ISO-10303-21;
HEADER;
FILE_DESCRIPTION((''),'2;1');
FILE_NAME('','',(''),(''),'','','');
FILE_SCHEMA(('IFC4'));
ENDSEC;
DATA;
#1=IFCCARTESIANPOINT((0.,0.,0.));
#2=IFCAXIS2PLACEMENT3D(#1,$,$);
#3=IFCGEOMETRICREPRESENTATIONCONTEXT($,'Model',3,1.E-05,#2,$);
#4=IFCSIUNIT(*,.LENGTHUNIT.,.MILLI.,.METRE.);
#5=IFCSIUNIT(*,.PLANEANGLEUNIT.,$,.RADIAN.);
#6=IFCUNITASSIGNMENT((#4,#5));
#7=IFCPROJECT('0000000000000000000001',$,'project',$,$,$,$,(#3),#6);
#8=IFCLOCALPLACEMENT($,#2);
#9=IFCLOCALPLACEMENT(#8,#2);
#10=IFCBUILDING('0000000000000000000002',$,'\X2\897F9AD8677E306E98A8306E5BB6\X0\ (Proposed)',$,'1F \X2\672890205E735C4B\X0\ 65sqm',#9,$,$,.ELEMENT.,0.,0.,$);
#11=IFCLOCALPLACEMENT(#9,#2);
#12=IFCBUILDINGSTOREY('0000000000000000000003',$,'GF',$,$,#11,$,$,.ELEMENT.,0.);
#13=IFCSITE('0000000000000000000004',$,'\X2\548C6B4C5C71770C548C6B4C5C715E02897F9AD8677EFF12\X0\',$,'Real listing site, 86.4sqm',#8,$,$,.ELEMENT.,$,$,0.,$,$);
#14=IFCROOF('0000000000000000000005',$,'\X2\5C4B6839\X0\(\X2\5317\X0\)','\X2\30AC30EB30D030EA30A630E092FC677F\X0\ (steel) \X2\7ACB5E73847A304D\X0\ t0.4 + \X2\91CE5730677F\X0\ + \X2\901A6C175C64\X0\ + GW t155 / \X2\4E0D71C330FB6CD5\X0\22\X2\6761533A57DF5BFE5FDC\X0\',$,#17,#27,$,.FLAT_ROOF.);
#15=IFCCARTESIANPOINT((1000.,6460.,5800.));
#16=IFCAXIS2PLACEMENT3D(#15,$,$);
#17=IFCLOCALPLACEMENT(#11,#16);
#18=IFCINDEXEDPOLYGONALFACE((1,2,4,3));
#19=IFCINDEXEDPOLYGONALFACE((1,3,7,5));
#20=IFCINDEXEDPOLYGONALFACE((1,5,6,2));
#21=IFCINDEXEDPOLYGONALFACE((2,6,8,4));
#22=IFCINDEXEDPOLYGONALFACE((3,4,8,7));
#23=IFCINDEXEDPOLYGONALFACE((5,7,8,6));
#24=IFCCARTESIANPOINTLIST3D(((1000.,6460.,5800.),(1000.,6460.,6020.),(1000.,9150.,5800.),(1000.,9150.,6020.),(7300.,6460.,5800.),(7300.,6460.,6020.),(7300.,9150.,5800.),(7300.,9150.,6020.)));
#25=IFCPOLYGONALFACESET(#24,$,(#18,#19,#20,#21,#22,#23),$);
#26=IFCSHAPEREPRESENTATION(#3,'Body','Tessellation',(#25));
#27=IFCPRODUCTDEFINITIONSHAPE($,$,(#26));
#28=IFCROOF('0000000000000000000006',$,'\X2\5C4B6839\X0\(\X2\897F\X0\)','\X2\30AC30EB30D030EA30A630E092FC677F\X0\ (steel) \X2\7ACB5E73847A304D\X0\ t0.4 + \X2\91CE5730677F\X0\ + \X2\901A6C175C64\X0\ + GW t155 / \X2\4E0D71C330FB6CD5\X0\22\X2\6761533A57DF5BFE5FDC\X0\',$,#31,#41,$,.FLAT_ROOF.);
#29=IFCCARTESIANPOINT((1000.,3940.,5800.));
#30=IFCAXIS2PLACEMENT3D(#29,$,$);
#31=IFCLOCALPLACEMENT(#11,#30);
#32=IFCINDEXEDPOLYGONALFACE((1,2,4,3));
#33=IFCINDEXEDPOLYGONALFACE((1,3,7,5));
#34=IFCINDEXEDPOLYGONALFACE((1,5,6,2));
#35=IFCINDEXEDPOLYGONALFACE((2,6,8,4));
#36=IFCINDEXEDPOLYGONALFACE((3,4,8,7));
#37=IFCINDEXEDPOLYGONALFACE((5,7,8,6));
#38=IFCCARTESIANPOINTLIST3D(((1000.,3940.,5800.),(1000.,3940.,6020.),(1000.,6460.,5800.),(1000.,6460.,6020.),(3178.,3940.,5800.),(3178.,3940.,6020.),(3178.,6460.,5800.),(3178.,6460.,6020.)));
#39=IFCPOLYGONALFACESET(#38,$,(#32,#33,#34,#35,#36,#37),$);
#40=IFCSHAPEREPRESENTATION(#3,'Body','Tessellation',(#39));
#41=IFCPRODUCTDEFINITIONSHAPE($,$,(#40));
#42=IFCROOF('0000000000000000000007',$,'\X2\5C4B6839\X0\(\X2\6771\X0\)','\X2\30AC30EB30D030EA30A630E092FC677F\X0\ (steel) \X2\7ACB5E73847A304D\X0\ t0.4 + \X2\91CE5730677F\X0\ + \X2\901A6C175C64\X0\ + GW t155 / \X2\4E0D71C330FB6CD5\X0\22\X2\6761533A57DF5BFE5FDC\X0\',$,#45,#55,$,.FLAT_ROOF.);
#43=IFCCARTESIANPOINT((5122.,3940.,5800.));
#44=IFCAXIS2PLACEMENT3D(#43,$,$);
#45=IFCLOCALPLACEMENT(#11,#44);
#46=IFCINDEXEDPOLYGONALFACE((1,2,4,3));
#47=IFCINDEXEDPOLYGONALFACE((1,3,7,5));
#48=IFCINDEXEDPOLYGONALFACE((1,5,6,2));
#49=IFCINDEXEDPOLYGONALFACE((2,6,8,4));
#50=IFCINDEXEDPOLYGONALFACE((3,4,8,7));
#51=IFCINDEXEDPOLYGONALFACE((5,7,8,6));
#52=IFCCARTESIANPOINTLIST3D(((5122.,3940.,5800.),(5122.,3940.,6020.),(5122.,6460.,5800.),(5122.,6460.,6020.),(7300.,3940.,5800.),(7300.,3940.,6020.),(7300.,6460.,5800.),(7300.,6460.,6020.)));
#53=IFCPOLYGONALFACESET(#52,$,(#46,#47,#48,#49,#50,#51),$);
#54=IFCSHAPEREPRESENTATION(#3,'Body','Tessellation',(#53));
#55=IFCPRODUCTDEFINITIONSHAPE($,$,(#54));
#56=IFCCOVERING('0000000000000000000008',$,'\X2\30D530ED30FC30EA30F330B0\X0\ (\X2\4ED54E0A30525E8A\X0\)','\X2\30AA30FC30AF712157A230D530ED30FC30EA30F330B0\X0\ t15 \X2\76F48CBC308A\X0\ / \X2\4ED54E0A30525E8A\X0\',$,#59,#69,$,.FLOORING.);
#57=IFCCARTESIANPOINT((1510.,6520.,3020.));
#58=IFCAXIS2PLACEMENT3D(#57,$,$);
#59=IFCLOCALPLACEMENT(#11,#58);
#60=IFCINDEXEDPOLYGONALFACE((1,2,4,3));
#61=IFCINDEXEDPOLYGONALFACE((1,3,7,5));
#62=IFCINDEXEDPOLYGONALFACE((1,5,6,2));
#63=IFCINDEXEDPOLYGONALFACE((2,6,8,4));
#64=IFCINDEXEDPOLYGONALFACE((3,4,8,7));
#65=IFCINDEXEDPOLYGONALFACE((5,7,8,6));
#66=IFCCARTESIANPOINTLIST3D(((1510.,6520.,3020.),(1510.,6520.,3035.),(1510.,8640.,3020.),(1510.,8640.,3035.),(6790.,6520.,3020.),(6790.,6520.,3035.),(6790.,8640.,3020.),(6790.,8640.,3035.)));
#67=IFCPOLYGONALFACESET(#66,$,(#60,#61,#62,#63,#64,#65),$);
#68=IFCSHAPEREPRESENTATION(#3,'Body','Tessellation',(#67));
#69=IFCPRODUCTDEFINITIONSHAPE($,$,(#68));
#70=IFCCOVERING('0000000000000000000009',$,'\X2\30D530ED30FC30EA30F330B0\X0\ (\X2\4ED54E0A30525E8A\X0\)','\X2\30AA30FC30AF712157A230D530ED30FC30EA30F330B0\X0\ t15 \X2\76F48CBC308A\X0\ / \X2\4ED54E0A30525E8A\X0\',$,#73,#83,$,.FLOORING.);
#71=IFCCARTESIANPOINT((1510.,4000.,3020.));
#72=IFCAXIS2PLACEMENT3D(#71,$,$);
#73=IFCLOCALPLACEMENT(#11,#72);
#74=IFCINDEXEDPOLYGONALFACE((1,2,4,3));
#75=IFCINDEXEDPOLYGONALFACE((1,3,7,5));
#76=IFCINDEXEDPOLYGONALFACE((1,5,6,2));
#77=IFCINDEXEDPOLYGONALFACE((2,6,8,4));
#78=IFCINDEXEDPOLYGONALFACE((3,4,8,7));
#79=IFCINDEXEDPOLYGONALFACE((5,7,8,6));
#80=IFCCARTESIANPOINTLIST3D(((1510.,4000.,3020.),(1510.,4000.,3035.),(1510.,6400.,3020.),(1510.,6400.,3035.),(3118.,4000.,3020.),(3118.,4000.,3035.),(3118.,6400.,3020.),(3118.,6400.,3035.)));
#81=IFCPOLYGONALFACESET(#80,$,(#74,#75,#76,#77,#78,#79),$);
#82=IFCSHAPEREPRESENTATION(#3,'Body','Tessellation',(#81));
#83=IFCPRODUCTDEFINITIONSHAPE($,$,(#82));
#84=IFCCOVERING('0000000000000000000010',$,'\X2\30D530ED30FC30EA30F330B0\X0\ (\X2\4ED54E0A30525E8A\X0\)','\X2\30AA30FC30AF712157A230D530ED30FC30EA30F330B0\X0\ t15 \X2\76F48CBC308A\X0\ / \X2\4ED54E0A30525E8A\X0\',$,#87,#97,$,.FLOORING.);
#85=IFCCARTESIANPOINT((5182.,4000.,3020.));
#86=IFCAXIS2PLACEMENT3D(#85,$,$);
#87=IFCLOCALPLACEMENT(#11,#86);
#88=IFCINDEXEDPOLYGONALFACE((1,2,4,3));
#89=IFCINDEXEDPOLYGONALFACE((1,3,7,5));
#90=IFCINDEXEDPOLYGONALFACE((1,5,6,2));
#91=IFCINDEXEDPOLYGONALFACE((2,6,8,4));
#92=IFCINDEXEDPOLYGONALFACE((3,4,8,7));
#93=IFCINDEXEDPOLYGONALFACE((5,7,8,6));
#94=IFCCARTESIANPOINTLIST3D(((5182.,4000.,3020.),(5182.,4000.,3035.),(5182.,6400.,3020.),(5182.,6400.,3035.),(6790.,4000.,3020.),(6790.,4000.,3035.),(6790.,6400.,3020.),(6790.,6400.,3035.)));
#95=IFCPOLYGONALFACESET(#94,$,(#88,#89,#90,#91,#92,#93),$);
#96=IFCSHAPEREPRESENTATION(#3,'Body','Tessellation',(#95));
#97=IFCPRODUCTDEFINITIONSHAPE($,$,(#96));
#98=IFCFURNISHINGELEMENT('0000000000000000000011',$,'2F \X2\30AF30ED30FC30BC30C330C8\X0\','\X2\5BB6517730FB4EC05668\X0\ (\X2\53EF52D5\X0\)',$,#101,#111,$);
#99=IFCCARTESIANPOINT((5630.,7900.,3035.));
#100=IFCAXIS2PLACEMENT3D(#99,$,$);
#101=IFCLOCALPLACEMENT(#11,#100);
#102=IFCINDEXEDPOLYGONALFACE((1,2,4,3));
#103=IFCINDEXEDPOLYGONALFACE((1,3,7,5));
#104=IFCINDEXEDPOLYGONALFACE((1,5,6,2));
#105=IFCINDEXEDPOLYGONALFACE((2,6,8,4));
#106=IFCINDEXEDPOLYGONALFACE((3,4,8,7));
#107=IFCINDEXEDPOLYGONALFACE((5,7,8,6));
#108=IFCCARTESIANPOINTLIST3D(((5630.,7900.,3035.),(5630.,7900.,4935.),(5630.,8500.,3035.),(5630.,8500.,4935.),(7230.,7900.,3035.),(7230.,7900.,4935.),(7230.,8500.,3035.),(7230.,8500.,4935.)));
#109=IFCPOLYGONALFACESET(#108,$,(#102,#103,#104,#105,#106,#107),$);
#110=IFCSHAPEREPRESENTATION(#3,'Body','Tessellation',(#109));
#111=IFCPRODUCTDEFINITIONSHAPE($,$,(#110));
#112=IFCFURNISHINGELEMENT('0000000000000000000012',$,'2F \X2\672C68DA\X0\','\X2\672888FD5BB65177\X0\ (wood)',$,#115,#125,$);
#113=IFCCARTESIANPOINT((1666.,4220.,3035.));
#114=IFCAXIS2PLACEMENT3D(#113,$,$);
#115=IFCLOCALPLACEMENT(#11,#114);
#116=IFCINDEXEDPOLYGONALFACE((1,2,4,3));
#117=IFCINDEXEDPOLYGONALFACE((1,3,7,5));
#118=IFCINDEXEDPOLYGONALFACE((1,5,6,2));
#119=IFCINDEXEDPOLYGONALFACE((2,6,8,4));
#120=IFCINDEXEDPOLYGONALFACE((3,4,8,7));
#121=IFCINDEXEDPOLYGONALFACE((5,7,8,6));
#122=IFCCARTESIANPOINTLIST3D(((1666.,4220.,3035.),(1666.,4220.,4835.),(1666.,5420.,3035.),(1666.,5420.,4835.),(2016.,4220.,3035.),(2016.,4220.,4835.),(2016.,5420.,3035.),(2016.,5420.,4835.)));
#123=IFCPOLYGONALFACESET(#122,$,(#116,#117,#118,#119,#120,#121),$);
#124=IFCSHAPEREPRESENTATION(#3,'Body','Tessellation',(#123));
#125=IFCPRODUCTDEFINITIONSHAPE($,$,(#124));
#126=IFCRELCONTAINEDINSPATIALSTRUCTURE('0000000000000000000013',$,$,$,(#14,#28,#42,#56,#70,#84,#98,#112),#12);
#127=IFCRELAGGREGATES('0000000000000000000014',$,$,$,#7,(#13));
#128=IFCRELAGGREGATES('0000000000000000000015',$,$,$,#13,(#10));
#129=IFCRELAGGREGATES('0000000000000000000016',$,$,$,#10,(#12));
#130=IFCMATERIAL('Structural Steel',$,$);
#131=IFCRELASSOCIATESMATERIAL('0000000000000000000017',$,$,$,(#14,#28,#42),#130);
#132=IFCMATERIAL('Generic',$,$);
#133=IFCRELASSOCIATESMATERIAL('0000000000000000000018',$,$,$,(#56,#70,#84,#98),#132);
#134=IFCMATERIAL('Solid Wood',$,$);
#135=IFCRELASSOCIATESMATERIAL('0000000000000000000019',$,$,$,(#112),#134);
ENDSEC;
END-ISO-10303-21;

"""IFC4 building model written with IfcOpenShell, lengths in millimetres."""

from ifc_helpers import new_model, si_unit, frame, frame_2d, origin, place, context, project, spatial, rectangle, extrude, material, element, save


model = new_model("IFC4")

# Units and contexts
model_context = context("Model", 3, precision=1e-05, world=origin())
ifc_project = project(units=[si_unit("LENGTHUNIT", "METRE", prefix="MILLI"), si_unit("PLANEANGLEUNIT", "RADIAN")], contexts=[model_context])

# Site, building, storey
site_placement = place(None, origin())
site = spatial("IfcSite", under=ifc_project, at=site_placement, Name="和歌山県和歌山市西高松２", ObjectType="Real listing site, 86.4sqm", CompositionType="ELEMENT", RefElevation=0.0)
building_placement = place(site_placement, origin())
building = spatial("IfcBuilding", under=site, at=building_placement, Name="西高松の風の家 (Proposed)", ObjectType="1F 木造平屋 65sqm", CompositionType="ELEMENT", ElevationOfRefHeight=0.0, ElevationOfTerrain=0.0)
storey_placement = place(building_placement, origin())
storey = spatial("IfcBuildingStorey", under=building, at=storey_placement, Name="GF", CompositionType="ELEMENT", Elevation=0.0)

# Shared definitions
ifc_material_1 = material(Name="Solid Wood")

# Shared definitions
ifc_material_2 = material(Name="Generic")

# Roofs
ifc_material_3 = material(Name="Structural Steel")
for number, where, name in (
    (1, (1000.0, 6460.0, 5800.0), "屋根(北)"),
):
    element("IfcRoof", number, at=place(storey_placement, frame(where)), inside=storey, material=ifc_material_3, Name=name, Description="ガルバリウム鋼板 (steel) 立平葺き t0.4 + 野地板 + 通気層 + GW t155 / 不燃・法22条区域対応", PredefinedType="FLAT_ROOF", context=model_context, shape_type="SweptSolid", body=[
        extrude(rectangle(XDim=6300.0, YDim=2690.0, at=frame_2d((3150.0, 1345.0))), frame((1000.0, 6460.0, 5800.0)), (0.0, 0.0, 1.0), 220.0),
    ])
roof_1_placement = place(storey_placement, frame((1000.0, 3940.0, 5800.0)))
element("IfcRoof", 2, at=roof_1_placement, inside=storey, material=ifc_material_3, Name="屋根(西)", Description="ガルバリウム鋼板 (steel) 立平葺き t0.4 + 野地板 + 通気層 + GW t155 / 不燃・法22条区域対応", PredefinedType="FLAT_ROOF", context=model_context, shape_type="SweptSolid", body=[
    extrude(rectangle(XDim=2178.0, YDim=2520.0, at=frame_2d((1089.0, 1260.0))), frame((1000.0, 3940.0, 5800.0)), (0.0, 0.0, 1.0), 220.0),
])
roof_2_placement = place(storey_placement, frame((5122.0, 3940.0, 5800.0)))
element("IfcRoof", 3, at=roof_2_placement, inside=storey, material=ifc_material_3, Name="屋根(東)", Description="ガルバリウム鋼板 (steel) 立平葺き t0.4 + 野地板 + 通気層 + GW t155 / 不燃・法22条区域対応", PredefinedType="FLAT_ROOF", context=model_context, shape_type="SweptSolid", body=[
    extrude(rectangle(XDim=2178.0, YDim=2520.0, at=frame_2d((1089.0, 1260.0))), frame((5122.0, 3940.0, 5800.0)), (0.0, 0.0, 1.0), 220.0),
])

# Coverings
covering_1_placement = place(storey_placement, frame((1510.0, 6520.0, 3020.0)))
element("IfcCovering", 4, at=covering_1_placement, inside=storey, material=ifc_material_2, Name="フローリング (仕上げ床)", Description="オーク無垢フローリング t15 直貼り / 仕上げ床", PredefinedType="FLOORING", context=model_context, shape_type="SweptSolid", body=[
    extrude(rectangle(XDim=5280.0, YDim=2120.0, at=frame_2d((2640.0, 1060.0))), frame((1510.0, 6520.0, 3020.0)), (0.0, 0.0, 1.0), 15.0),
])
covering_2_placement = place(storey_placement, frame((1510.0, 4000.0, 3020.0)))
element("IfcCovering", 5, at=covering_2_placement, inside=storey, material=ifc_material_2, Name="フローリング (仕上げ床)", Description="オーク無垢フローリング t15 直貼り / 仕上げ床", PredefinedType="FLOORING", context=model_context, shape_type="SweptSolid", body=[
    extrude(rectangle(XDim=1608.0, YDim=2400.0, at=frame_2d((804.0, 1200.0))), frame((1510.0, 4000.0, 3020.0)), (0.0, 0.0, 1.0), 15.0),
])
covering_3_placement = place(storey_placement, frame((5182.0, 4000.0, 3020.0)))
element("IfcCovering", 6, at=covering_3_placement, inside=storey, material=ifc_material_2, Name="フローリング (仕上げ床)", Description="オーク無垢フローリング t15 直貼り / 仕上げ床", PredefinedType="FLOORING", context=model_context, shape_type="SweptSolid", body=[
    extrude(rectangle(XDim=1608.0, YDim=2400.0, at=frame_2d((804.0, 1200.0))), frame((5182.0, 4000.0, 3020.0)), (0.0, 0.0, 1.0), 15.0),
])

# Furnishing elements
furnishing_1_placement = place(storey_placement, frame((5630.0, 7900.0, 3035.0)))
element("IfcFurnishingElement", 7, at=furnishing_1_placement, inside=storey, material=ifc_material_2, Name="2F クローゼット", Description="家具・什器 (可動)", context=model_context, shape_type="SweptSolid", body=[
    extrude(rectangle(XDim=1600.0, YDim=600.0, at=frame_2d((800.0, 300.0))), frame((5630.0, 7900.0, 3035.0)), (0.0, 0.0, 1.0), 1900.0),
])
furnishing_2_placement = place(storey_placement, frame((1666.0, 4220.0, 3035.0)))
element("IfcFurnishingElement", 8, at=furnishing_2_placement, inside=storey, material=ifc_material_1, Name="2F 本棚", Description="木製家具 (wood)", context=model_context, shape_type="SweptSolid", body=[
    extrude(rectangle(XDim=350.0, YDim=1200.0, at=frame_2d((175.0, 600.0))), frame((1666.0, 4220.0, 3035.0)), (0.0, 0.0, 1.0), 1800.0),
])

save(model, "model.ifc")
